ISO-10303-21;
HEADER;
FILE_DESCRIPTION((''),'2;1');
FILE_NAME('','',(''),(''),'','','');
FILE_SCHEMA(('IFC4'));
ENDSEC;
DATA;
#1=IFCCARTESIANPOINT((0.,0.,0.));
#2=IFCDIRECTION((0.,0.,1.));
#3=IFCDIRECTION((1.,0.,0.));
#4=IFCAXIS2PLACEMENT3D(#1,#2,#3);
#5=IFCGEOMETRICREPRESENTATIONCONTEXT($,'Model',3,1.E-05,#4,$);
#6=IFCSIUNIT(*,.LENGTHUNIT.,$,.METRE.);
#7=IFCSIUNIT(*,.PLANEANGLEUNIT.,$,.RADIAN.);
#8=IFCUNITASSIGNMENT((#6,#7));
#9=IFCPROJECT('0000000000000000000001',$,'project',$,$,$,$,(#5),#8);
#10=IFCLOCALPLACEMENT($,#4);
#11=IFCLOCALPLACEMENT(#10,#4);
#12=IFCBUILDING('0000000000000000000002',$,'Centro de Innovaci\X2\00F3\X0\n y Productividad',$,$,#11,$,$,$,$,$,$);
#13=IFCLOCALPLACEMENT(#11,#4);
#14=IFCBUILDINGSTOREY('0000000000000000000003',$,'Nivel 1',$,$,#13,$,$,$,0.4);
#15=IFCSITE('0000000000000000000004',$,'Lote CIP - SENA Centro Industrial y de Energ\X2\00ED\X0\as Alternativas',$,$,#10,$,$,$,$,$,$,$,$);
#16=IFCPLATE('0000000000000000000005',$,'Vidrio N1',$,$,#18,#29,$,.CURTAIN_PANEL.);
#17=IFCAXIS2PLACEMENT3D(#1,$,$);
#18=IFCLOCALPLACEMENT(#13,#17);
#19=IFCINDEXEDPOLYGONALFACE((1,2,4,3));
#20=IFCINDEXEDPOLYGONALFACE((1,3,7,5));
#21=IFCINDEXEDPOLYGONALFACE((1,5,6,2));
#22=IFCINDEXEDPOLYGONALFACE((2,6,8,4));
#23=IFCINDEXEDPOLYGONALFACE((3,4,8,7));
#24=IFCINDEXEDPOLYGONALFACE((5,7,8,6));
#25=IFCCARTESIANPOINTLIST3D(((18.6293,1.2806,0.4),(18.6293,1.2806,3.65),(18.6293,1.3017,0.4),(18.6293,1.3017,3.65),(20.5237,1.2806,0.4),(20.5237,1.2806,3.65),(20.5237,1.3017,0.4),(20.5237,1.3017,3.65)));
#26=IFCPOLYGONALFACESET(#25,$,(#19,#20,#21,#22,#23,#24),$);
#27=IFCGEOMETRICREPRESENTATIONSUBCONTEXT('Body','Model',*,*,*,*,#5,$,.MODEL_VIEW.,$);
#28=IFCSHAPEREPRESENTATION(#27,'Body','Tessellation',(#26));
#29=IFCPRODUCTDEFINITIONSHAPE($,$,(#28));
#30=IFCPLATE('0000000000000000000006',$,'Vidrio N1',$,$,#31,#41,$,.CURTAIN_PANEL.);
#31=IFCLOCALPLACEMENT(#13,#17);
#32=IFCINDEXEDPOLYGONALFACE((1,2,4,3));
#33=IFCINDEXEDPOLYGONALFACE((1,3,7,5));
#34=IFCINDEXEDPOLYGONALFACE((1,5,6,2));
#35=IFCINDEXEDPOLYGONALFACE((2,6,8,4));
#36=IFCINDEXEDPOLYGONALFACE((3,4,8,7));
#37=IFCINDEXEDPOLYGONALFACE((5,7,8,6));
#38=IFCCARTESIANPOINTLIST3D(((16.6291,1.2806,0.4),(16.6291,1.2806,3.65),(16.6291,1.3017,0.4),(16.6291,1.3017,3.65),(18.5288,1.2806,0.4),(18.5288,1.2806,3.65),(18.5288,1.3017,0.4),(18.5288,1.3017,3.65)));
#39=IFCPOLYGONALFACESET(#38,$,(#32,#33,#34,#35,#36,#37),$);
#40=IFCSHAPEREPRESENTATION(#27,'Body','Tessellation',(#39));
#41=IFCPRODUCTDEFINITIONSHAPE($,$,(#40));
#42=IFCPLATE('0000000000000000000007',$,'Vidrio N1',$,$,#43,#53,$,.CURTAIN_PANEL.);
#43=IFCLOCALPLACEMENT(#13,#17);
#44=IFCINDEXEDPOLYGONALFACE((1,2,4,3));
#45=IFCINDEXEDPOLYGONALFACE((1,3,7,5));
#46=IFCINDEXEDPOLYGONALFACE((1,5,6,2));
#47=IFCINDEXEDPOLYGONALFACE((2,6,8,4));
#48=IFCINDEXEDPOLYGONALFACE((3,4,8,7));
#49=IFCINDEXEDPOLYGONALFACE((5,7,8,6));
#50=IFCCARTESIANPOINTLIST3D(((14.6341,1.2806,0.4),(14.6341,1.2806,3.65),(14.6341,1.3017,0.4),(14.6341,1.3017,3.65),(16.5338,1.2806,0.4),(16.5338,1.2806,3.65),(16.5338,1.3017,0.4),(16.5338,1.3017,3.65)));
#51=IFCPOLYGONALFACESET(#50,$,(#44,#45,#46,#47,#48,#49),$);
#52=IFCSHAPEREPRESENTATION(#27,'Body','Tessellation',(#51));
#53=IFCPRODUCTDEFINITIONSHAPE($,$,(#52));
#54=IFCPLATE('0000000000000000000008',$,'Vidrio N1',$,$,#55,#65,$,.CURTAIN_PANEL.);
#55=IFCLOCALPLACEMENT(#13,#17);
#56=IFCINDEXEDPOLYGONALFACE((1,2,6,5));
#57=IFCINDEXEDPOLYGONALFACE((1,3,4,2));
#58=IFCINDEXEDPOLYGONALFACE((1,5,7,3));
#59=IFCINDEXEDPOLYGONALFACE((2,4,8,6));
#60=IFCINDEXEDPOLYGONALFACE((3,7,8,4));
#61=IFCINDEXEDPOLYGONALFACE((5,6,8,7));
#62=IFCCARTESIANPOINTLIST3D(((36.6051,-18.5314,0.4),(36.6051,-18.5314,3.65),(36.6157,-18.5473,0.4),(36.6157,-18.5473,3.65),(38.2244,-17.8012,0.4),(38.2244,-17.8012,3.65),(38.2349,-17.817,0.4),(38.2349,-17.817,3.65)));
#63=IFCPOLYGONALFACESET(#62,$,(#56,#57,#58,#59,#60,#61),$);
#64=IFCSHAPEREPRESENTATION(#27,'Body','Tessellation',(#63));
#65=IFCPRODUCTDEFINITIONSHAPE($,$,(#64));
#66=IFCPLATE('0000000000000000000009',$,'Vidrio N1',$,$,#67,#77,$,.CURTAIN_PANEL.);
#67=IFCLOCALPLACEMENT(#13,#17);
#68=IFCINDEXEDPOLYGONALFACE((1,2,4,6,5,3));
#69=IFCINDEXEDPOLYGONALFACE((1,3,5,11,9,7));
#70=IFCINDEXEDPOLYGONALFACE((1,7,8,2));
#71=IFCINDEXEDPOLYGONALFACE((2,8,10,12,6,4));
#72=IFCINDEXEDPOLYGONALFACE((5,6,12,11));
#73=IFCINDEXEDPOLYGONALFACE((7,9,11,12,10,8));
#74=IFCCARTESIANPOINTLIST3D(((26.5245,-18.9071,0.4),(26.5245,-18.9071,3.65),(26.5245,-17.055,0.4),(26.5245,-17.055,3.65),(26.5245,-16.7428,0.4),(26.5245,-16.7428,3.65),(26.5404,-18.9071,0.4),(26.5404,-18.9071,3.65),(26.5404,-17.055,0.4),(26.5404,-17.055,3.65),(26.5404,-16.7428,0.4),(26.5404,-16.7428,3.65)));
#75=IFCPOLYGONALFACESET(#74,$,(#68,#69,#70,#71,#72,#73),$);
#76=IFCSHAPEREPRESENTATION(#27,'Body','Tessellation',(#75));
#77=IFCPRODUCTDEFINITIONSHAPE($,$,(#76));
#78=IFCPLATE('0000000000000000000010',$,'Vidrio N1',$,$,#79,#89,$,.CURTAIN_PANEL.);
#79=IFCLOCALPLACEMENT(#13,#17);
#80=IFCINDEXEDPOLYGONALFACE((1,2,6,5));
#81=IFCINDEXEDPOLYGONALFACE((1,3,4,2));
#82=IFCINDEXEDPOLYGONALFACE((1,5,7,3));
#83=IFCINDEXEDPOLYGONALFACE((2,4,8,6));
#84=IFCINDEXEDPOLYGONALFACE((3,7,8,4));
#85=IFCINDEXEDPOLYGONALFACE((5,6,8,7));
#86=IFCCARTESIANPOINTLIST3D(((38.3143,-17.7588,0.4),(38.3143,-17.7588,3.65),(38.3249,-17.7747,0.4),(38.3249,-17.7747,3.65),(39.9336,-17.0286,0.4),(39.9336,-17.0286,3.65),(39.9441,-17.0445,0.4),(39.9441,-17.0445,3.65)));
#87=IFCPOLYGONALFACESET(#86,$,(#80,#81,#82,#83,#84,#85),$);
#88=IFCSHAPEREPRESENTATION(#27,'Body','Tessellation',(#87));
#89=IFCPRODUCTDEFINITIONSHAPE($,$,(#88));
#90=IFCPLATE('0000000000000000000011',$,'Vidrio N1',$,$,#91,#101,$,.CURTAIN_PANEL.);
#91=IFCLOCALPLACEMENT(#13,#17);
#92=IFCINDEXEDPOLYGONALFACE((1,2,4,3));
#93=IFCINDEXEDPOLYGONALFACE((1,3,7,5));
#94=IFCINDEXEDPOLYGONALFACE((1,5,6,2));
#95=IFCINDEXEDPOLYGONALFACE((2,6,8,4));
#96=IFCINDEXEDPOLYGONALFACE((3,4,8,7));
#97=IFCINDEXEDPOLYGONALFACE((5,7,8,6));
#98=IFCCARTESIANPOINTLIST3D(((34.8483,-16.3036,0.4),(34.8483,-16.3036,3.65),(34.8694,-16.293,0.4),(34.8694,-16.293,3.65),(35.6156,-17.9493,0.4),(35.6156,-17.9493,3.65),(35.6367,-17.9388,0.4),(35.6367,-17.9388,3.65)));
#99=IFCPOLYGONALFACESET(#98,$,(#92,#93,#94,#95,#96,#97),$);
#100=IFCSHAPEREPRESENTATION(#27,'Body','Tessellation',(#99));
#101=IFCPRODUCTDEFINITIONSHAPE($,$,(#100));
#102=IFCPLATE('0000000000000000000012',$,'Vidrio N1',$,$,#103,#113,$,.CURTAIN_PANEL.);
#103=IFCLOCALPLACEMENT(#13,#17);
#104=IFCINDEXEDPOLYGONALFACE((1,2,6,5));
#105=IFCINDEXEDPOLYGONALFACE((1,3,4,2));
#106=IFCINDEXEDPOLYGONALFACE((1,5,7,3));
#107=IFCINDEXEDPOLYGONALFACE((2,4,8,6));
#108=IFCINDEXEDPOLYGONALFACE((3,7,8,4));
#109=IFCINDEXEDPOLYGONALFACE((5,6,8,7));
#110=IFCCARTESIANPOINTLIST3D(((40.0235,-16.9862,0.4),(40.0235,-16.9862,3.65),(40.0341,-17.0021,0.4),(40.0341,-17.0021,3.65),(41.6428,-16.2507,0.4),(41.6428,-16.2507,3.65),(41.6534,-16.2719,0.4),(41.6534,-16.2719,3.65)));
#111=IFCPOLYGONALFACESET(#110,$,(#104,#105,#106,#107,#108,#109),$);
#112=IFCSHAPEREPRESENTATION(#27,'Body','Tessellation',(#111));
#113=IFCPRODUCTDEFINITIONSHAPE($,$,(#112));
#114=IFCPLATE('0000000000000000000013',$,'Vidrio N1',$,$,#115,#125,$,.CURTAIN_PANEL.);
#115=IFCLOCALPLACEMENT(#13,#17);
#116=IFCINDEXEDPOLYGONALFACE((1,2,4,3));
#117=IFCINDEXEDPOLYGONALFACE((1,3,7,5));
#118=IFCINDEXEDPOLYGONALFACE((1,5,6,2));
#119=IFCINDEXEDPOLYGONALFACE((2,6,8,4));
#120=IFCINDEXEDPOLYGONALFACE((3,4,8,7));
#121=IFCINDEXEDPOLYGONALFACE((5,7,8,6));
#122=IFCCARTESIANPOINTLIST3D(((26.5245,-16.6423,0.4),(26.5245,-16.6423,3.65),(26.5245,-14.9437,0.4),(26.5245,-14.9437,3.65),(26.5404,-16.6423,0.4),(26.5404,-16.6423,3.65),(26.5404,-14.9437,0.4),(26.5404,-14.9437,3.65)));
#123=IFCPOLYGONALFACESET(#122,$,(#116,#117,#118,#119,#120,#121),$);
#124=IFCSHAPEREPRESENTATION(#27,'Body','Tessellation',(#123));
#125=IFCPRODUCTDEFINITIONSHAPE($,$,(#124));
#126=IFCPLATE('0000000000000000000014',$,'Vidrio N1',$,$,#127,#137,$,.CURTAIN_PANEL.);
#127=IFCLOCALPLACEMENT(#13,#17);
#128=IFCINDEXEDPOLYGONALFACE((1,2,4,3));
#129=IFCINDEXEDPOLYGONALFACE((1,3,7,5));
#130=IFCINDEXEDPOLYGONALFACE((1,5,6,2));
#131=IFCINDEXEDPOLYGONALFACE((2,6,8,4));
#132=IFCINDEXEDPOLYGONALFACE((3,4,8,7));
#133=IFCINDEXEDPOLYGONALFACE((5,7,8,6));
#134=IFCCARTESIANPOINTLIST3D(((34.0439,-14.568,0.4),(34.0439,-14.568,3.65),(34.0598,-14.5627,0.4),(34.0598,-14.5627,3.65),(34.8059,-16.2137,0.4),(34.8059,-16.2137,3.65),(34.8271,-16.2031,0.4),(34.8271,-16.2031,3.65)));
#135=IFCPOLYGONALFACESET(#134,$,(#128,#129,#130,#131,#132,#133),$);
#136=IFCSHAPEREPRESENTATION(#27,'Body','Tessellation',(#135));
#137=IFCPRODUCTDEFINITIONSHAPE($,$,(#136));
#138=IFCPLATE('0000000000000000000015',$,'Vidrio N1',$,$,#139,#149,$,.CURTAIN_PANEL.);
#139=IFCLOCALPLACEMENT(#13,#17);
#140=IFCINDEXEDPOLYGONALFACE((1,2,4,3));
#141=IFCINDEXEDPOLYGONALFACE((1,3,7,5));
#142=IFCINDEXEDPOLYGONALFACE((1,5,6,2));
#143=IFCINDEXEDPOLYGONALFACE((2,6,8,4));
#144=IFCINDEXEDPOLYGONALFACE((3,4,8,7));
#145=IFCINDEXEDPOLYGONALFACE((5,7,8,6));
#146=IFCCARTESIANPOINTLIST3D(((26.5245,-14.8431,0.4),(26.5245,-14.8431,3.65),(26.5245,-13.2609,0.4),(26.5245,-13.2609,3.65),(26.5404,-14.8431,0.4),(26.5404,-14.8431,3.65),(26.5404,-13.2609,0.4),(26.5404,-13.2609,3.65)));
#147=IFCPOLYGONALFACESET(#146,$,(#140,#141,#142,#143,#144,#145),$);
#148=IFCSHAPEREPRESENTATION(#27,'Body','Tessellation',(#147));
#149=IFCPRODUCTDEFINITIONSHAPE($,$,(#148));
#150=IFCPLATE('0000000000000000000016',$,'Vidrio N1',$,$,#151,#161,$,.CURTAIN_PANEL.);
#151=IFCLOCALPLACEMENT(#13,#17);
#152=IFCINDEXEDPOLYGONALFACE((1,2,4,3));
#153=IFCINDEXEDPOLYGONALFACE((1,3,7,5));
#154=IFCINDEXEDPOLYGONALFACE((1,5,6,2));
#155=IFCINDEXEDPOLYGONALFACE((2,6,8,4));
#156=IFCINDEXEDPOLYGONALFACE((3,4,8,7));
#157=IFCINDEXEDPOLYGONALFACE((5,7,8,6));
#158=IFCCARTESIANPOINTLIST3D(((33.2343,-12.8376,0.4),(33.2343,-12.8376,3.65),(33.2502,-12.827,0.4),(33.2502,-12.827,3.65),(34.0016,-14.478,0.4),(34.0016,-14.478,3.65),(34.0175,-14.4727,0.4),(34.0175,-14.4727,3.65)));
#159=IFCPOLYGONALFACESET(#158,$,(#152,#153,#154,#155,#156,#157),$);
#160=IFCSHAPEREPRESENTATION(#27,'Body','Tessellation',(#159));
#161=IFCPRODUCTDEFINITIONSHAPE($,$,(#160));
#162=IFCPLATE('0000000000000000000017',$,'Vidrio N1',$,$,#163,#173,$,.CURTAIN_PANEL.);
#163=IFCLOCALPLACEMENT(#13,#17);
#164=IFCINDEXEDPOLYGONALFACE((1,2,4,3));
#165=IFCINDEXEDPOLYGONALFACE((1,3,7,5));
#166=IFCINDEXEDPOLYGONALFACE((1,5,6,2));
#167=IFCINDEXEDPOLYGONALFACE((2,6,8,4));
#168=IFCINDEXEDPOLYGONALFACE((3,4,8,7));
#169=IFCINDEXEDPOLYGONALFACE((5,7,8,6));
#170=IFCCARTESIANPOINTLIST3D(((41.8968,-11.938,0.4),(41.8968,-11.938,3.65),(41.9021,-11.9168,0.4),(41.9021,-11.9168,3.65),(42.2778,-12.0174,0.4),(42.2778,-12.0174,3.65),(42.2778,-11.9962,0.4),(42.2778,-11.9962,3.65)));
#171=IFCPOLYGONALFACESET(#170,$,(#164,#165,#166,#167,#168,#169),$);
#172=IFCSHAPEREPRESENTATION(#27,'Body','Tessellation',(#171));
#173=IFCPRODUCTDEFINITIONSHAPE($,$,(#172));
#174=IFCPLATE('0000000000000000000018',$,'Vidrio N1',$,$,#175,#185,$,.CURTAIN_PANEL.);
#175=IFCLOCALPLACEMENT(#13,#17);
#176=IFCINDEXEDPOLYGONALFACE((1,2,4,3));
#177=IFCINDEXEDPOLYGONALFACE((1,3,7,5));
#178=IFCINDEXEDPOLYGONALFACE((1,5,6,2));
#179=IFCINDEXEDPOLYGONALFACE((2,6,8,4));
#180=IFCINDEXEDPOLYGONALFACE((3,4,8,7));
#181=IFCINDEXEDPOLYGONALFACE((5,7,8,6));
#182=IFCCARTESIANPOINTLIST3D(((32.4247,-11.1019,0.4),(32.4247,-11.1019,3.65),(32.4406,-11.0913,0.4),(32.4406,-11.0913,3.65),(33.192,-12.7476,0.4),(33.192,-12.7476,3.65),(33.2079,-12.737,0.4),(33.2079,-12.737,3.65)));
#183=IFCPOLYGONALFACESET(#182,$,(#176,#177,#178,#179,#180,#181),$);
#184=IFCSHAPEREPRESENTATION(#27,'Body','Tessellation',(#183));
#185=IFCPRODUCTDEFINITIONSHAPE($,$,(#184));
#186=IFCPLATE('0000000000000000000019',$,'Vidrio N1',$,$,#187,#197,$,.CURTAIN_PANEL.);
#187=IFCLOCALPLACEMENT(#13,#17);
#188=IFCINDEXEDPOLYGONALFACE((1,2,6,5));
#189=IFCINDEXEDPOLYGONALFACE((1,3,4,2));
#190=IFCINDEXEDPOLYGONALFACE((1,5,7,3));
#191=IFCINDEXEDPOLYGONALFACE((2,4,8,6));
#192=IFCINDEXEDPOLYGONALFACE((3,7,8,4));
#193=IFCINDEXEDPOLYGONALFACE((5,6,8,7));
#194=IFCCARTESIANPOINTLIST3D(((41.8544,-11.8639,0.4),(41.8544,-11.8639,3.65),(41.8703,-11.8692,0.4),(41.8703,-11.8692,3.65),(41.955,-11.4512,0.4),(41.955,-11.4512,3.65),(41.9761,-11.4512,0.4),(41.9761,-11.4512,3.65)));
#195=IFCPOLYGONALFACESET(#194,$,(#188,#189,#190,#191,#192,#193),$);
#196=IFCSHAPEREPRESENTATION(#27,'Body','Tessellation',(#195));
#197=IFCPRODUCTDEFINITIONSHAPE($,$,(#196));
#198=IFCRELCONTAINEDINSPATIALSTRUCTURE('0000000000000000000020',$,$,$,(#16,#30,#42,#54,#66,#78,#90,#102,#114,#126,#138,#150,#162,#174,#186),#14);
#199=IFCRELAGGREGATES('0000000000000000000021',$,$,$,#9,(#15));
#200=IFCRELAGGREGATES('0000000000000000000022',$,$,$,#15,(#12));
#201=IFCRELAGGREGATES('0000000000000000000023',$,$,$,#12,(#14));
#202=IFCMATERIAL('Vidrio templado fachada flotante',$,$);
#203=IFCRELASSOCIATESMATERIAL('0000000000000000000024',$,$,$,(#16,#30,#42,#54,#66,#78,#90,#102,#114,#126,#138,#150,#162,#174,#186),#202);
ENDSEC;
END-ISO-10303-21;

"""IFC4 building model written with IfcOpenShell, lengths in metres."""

from ifc_helpers import new_model, si_unit, frame, origin_with_axes, place, context, subcontext, project, spatial, polyline, outline, extrude, material, element, save


model = new_model("IFC4")

# Units and contexts
model_context = context("Model", 3, precision=1e-05, world=origin_with_axes())
body_context = subcontext(model_context, "Body", "Model", "MODEL_VIEW")
ifc_project = project(units=[si_unit("LENGTHUNIT", "METRE"), si_unit("PLANEANGLEUNIT", "RADIAN")], contexts=[model_context])

# Site, building, storey
site_placement = place(None, origin_with_axes())
site = spatial("IfcSite", under=ifc_project, at=site_placement, Name="Lote CIP - SENA Centro Industrial y de Energías Alternativas")
building_placement = place(site_placement, origin_with_axes())
building = spatial("IfcBuilding", under=site, at=building_placement, Name="Centro de Innovación y Productividad")
storey_placement = place(building_placement, origin_with_axes())
storey = spatial("IfcBuildingStorey", under=building, at=storey_placement, Name="Nivel 1", Elevation=0.4)

# Plates
ifc_material = material(Name="Vidrio templado fachada flotante")
plate_1_placement = place(storey_placement, origin_with_axes())
element("IfcPlate", 1, at=plate_1_placement, inside=storey, material=ifc_material, Name="Vidrio N1", PredefinedType="CURTAIN_PANEL", context=body_context, shape_type="SweptSolid", body=[
    extrude(outline(polyline([(20.5237, 1.3017), (20.5237, 1.2806), (18.6293, 1.2806), (18.6293, 1.3017), (20.5237, 1.3017)])), frame((0.0, 0.0, 0.4)), (0.0, 0.0, 1.0), 3.25),
])
plate_2_placement = place(storey_placement, origin_with_axes())
element("IfcPlate", 2, at=plate_2_placement, inside=storey, material=ifc_material, Name="Vidrio N1", PredefinedType="CURTAIN_PANEL", context=body_context, shape_type="SweptSolid", body=[
    extrude(outline(polyline([(16.6291, 1.3017), (18.5288, 1.3017), (18.5288, 1.2806), (16.6291, 1.2806), (16.6291, 1.3017)])), frame((0.0, 0.0, 0.4)), (0.0, 0.0, 1.0), 3.25),
])
plate_3_placement = place(storey_placement, origin_with_axes())
element("IfcPlate", 3, at=plate_3_placement, inside=storey, material=ifc_material, Name="Vidrio N1", PredefinedType="CURTAIN_PANEL", context=body_context, shape_type="SweptSolid", body=[
    extrude(outline(polyline([(14.6341, 1.2806), (14.6341, 1.3017), (16.5338, 1.3017), (16.5338, 1.2806), (14.6341, 1.2806)])), frame((0.0, 0.0, 0.4)), (0.0, 0.0, 1.0), 3.25),
])
plate_4_placement = place(storey_placement, origin_with_axes())
element("IfcPlate", 4, at=plate_4_placement, inside=storey, material=ifc_material, Name="Vidrio N1", PredefinedType="CURTAIN_PANEL", context=body_context, shape_type="SweptSolid", body=[
    extrude(outline(polyline([(38.2349, -17.817), (36.6157, -18.5473), (36.6051, -18.5314), (38.2244, -17.8012), (38.2349, -17.817)])), frame((0.0, 0.0, 0.4)), (0.0, 0.0, 1.0), 3.25),
])
plate_5_placement = place(storey_placement, origin_with_axes())
element("IfcPlate", 5, at=plate_5_placement, inside=storey, material=ifc_material, Name="Vidrio N1", PredefinedType="CURTAIN_PANEL", context=body_context, shape_type="SweptSolid", body=[
    extrude(outline(polyline([(26.5404, -17.055), (26.5404, -18.9071), (26.5245, -18.9071), (26.5245, -17.055), (26.5245, -16.7428), (26.5404, -16.7428), (26.5404, -17.055)])), frame((0.0, 0.0, 0.4)), (0.0, 0.0, 1.0), 3.25),
])
plate_6_placement = place(storey_placement, origin_with_axes())
element("IfcPlate", 6, at=plate_6_placement, inside=storey, material=ifc_material, Name="Vidrio N1", PredefinedType="CURTAIN_PANEL", context=body_context, shape_type="SweptSolid", body=[
    extrude(outline(polyline([(38.3249, -17.7747), (38.3143, -17.7588), (39.9336, -17.0286), (39.9441, -17.0445), (38.3249, -17.7747)])), frame((0.0, 0.0, 0.4)), (0.0, 0.0, 1.0), 3.25),
])
plate_7_placement = place(storey_placement, origin_with_axes())
element("IfcPlate", 7, at=plate_7_placement, inside=storey, material=ifc_material, Name="Vidrio N1", PredefinedType="CURTAIN_PANEL", context=body_context, shape_type="SweptSolid", body=[
    extrude(outline(polyline([(35.6367, -17.9387), (35.6156, -17.9493), (34.8483, -16.3036), (34.8694, -16.293), (35.6367, -17.9387)])), frame((0.0, 0.0, 0.4)), (0.0, 0.0, 1.0), 3.25),
])
plate_8_placement = place(storey_placement, origin_with_axes())
element("IfcPlate", 8, at=plate_8_placement, inside=storey, material=ifc_material, Name="Vidrio N1", PredefinedType="CURTAIN_PANEL", context=body_context, shape_type="SweptSolid", body=[
    extrude(outline(polyline([(41.6534, -16.2719), (40.0341, -17.0021), (40.0235, -16.9862), (41.6428, -16.2507), (41.6534, -16.2719)])), frame((0.0, 0.0, 0.4)), (0.0, 0.0, 1.0), 3.25),
])
plate_9_placement = place(storey_placement, origin_with_axes())
element("IfcPlate", 9, at=plate_9_placement, inside=storey, material=ifc_material, Name="Vidrio N1", PredefinedType="CURTAIN_PANEL", context=body_context, shape_type="SweptSolid", body=[
    extrude(outline(polyline([(26.5404, -14.9437), (26.5404, -16.6423), (26.5245, -16.6423), (26.5245, -14.9437), (26.5404, -14.9437)])), frame((0.0, 0.0, 0.4)), (0.0, 0.0, 1.0), 3.25),
])
plate_10_placement = place(storey_placement, origin_with_axes())
element("IfcPlate", 10, at=plate_10_placement, inside=storey, material=ifc_material, Name="Vidrio N1", PredefinedType="CURTAIN_PANEL", context=body_context, shape_type="SweptSolid", body=[
    extrude(outline(polyline([(34.8271, -16.2031), (34.8059, -16.2137), (34.0439, -14.568), (34.0598, -14.5627), (34.8271, -16.2031)])), frame((0.0, 0.0, 0.4)), (0.0, 0.0, 1.0), 3.25),
])
plate_11_placement = place(storey_placement, origin_with_axes())
element("IfcPlate", 11, at=plate_11_placement, inside=storey, material=ifc_material, Name="Vidrio N1", PredefinedType="CURTAIN_PANEL", context=body_context, shape_type="SweptSolid", body=[
    extrude(outline(polyline([(26.5404, -13.2609), (26.5404, -14.8431), (26.5245, -14.8431), (26.5245, -13.2609), (26.5404, -13.2609)])), frame((0.0, 0.0, 0.4)), (0.0, 0.0, 1.0), 3.25),
])
plate_12_placement = place(storey_placement, origin_with_axes())
element("IfcPlate", 12, at=plate_12_placement, inside=storey, material=ifc_material, Name="Vidrio N1", PredefinedType="CURTAIN_PANEL", context=body_context, shape_type="SweptSolid", body=[
    extrude(outline(polyline([(34.0175, -14.4727), (34.0016, -14.478), (33.2343, -12.8376), (33.2502, -12.827), (34.0175, -14.4727)])), frame((0.0, 0.0, 0.4)), (0.0, 0.0, 1.0), 3.25),
])
plate_13_placement = place(storey_placement, origin_with_axes())
element("IfcPlate", 13, at=plate_13_placement, inside=storey, material=ifc_material, Name="Vidrio N1", PredefinedType="CURTAIN_PANEL", context=body_context, shape_type="SweptSolid", body=[
    extrude(outline(polyline([(42.2778, -12.0174), (41.8968, -11.938), (41.9021, -11.9168), (42.2778, -11.9962), (42.2778, -12.0174)])), frame((0.0, 0.0, 0.4)), (0.0, 0.0, 1.0), 3.25),
])
plate_14_placement = place(storey_placement, origin_with_axes())
element("IfcPlate", 14, at=plate_14_placement, inside=storey, material=ifc_material, Name="Vidrio N1", PredefinedType="CURTAIN_PANEL", context=body_context, shape_type="SweptSolid", body=[
    extrude(outline(polyline([(32.4247, -11.1019), (32.4406, -11.0913), (33.2079, -12.737), (33.192, -12.7476), (32.4247, -11.1019)])), frame((0.0, 0.0, 0.4)), (0.0, 0.0, 1.0), 3.25),
])
plate_15_placement = place(storey_placement, origin_with_axes())
element("IfcPlate", 15, at=plate_15_placement, inside=storey, material=ifc_material, Name="Vidrio N1", PredefinedType="CURTAIN_PANEL", context=body_context, shape_type="SweptSolid", body=[
    extrude(outline(polyline([(41.8703, -11.8692), (41.8544, -11.8639), (41.955, -11.4512), (41.9761, -11.4512), (41.8703, -11.8692)])), frame((0.0, 0.0, 0.4)), (0.0, 0.0, 1.0), 3.25),
])

save(model, "model.ifc")
